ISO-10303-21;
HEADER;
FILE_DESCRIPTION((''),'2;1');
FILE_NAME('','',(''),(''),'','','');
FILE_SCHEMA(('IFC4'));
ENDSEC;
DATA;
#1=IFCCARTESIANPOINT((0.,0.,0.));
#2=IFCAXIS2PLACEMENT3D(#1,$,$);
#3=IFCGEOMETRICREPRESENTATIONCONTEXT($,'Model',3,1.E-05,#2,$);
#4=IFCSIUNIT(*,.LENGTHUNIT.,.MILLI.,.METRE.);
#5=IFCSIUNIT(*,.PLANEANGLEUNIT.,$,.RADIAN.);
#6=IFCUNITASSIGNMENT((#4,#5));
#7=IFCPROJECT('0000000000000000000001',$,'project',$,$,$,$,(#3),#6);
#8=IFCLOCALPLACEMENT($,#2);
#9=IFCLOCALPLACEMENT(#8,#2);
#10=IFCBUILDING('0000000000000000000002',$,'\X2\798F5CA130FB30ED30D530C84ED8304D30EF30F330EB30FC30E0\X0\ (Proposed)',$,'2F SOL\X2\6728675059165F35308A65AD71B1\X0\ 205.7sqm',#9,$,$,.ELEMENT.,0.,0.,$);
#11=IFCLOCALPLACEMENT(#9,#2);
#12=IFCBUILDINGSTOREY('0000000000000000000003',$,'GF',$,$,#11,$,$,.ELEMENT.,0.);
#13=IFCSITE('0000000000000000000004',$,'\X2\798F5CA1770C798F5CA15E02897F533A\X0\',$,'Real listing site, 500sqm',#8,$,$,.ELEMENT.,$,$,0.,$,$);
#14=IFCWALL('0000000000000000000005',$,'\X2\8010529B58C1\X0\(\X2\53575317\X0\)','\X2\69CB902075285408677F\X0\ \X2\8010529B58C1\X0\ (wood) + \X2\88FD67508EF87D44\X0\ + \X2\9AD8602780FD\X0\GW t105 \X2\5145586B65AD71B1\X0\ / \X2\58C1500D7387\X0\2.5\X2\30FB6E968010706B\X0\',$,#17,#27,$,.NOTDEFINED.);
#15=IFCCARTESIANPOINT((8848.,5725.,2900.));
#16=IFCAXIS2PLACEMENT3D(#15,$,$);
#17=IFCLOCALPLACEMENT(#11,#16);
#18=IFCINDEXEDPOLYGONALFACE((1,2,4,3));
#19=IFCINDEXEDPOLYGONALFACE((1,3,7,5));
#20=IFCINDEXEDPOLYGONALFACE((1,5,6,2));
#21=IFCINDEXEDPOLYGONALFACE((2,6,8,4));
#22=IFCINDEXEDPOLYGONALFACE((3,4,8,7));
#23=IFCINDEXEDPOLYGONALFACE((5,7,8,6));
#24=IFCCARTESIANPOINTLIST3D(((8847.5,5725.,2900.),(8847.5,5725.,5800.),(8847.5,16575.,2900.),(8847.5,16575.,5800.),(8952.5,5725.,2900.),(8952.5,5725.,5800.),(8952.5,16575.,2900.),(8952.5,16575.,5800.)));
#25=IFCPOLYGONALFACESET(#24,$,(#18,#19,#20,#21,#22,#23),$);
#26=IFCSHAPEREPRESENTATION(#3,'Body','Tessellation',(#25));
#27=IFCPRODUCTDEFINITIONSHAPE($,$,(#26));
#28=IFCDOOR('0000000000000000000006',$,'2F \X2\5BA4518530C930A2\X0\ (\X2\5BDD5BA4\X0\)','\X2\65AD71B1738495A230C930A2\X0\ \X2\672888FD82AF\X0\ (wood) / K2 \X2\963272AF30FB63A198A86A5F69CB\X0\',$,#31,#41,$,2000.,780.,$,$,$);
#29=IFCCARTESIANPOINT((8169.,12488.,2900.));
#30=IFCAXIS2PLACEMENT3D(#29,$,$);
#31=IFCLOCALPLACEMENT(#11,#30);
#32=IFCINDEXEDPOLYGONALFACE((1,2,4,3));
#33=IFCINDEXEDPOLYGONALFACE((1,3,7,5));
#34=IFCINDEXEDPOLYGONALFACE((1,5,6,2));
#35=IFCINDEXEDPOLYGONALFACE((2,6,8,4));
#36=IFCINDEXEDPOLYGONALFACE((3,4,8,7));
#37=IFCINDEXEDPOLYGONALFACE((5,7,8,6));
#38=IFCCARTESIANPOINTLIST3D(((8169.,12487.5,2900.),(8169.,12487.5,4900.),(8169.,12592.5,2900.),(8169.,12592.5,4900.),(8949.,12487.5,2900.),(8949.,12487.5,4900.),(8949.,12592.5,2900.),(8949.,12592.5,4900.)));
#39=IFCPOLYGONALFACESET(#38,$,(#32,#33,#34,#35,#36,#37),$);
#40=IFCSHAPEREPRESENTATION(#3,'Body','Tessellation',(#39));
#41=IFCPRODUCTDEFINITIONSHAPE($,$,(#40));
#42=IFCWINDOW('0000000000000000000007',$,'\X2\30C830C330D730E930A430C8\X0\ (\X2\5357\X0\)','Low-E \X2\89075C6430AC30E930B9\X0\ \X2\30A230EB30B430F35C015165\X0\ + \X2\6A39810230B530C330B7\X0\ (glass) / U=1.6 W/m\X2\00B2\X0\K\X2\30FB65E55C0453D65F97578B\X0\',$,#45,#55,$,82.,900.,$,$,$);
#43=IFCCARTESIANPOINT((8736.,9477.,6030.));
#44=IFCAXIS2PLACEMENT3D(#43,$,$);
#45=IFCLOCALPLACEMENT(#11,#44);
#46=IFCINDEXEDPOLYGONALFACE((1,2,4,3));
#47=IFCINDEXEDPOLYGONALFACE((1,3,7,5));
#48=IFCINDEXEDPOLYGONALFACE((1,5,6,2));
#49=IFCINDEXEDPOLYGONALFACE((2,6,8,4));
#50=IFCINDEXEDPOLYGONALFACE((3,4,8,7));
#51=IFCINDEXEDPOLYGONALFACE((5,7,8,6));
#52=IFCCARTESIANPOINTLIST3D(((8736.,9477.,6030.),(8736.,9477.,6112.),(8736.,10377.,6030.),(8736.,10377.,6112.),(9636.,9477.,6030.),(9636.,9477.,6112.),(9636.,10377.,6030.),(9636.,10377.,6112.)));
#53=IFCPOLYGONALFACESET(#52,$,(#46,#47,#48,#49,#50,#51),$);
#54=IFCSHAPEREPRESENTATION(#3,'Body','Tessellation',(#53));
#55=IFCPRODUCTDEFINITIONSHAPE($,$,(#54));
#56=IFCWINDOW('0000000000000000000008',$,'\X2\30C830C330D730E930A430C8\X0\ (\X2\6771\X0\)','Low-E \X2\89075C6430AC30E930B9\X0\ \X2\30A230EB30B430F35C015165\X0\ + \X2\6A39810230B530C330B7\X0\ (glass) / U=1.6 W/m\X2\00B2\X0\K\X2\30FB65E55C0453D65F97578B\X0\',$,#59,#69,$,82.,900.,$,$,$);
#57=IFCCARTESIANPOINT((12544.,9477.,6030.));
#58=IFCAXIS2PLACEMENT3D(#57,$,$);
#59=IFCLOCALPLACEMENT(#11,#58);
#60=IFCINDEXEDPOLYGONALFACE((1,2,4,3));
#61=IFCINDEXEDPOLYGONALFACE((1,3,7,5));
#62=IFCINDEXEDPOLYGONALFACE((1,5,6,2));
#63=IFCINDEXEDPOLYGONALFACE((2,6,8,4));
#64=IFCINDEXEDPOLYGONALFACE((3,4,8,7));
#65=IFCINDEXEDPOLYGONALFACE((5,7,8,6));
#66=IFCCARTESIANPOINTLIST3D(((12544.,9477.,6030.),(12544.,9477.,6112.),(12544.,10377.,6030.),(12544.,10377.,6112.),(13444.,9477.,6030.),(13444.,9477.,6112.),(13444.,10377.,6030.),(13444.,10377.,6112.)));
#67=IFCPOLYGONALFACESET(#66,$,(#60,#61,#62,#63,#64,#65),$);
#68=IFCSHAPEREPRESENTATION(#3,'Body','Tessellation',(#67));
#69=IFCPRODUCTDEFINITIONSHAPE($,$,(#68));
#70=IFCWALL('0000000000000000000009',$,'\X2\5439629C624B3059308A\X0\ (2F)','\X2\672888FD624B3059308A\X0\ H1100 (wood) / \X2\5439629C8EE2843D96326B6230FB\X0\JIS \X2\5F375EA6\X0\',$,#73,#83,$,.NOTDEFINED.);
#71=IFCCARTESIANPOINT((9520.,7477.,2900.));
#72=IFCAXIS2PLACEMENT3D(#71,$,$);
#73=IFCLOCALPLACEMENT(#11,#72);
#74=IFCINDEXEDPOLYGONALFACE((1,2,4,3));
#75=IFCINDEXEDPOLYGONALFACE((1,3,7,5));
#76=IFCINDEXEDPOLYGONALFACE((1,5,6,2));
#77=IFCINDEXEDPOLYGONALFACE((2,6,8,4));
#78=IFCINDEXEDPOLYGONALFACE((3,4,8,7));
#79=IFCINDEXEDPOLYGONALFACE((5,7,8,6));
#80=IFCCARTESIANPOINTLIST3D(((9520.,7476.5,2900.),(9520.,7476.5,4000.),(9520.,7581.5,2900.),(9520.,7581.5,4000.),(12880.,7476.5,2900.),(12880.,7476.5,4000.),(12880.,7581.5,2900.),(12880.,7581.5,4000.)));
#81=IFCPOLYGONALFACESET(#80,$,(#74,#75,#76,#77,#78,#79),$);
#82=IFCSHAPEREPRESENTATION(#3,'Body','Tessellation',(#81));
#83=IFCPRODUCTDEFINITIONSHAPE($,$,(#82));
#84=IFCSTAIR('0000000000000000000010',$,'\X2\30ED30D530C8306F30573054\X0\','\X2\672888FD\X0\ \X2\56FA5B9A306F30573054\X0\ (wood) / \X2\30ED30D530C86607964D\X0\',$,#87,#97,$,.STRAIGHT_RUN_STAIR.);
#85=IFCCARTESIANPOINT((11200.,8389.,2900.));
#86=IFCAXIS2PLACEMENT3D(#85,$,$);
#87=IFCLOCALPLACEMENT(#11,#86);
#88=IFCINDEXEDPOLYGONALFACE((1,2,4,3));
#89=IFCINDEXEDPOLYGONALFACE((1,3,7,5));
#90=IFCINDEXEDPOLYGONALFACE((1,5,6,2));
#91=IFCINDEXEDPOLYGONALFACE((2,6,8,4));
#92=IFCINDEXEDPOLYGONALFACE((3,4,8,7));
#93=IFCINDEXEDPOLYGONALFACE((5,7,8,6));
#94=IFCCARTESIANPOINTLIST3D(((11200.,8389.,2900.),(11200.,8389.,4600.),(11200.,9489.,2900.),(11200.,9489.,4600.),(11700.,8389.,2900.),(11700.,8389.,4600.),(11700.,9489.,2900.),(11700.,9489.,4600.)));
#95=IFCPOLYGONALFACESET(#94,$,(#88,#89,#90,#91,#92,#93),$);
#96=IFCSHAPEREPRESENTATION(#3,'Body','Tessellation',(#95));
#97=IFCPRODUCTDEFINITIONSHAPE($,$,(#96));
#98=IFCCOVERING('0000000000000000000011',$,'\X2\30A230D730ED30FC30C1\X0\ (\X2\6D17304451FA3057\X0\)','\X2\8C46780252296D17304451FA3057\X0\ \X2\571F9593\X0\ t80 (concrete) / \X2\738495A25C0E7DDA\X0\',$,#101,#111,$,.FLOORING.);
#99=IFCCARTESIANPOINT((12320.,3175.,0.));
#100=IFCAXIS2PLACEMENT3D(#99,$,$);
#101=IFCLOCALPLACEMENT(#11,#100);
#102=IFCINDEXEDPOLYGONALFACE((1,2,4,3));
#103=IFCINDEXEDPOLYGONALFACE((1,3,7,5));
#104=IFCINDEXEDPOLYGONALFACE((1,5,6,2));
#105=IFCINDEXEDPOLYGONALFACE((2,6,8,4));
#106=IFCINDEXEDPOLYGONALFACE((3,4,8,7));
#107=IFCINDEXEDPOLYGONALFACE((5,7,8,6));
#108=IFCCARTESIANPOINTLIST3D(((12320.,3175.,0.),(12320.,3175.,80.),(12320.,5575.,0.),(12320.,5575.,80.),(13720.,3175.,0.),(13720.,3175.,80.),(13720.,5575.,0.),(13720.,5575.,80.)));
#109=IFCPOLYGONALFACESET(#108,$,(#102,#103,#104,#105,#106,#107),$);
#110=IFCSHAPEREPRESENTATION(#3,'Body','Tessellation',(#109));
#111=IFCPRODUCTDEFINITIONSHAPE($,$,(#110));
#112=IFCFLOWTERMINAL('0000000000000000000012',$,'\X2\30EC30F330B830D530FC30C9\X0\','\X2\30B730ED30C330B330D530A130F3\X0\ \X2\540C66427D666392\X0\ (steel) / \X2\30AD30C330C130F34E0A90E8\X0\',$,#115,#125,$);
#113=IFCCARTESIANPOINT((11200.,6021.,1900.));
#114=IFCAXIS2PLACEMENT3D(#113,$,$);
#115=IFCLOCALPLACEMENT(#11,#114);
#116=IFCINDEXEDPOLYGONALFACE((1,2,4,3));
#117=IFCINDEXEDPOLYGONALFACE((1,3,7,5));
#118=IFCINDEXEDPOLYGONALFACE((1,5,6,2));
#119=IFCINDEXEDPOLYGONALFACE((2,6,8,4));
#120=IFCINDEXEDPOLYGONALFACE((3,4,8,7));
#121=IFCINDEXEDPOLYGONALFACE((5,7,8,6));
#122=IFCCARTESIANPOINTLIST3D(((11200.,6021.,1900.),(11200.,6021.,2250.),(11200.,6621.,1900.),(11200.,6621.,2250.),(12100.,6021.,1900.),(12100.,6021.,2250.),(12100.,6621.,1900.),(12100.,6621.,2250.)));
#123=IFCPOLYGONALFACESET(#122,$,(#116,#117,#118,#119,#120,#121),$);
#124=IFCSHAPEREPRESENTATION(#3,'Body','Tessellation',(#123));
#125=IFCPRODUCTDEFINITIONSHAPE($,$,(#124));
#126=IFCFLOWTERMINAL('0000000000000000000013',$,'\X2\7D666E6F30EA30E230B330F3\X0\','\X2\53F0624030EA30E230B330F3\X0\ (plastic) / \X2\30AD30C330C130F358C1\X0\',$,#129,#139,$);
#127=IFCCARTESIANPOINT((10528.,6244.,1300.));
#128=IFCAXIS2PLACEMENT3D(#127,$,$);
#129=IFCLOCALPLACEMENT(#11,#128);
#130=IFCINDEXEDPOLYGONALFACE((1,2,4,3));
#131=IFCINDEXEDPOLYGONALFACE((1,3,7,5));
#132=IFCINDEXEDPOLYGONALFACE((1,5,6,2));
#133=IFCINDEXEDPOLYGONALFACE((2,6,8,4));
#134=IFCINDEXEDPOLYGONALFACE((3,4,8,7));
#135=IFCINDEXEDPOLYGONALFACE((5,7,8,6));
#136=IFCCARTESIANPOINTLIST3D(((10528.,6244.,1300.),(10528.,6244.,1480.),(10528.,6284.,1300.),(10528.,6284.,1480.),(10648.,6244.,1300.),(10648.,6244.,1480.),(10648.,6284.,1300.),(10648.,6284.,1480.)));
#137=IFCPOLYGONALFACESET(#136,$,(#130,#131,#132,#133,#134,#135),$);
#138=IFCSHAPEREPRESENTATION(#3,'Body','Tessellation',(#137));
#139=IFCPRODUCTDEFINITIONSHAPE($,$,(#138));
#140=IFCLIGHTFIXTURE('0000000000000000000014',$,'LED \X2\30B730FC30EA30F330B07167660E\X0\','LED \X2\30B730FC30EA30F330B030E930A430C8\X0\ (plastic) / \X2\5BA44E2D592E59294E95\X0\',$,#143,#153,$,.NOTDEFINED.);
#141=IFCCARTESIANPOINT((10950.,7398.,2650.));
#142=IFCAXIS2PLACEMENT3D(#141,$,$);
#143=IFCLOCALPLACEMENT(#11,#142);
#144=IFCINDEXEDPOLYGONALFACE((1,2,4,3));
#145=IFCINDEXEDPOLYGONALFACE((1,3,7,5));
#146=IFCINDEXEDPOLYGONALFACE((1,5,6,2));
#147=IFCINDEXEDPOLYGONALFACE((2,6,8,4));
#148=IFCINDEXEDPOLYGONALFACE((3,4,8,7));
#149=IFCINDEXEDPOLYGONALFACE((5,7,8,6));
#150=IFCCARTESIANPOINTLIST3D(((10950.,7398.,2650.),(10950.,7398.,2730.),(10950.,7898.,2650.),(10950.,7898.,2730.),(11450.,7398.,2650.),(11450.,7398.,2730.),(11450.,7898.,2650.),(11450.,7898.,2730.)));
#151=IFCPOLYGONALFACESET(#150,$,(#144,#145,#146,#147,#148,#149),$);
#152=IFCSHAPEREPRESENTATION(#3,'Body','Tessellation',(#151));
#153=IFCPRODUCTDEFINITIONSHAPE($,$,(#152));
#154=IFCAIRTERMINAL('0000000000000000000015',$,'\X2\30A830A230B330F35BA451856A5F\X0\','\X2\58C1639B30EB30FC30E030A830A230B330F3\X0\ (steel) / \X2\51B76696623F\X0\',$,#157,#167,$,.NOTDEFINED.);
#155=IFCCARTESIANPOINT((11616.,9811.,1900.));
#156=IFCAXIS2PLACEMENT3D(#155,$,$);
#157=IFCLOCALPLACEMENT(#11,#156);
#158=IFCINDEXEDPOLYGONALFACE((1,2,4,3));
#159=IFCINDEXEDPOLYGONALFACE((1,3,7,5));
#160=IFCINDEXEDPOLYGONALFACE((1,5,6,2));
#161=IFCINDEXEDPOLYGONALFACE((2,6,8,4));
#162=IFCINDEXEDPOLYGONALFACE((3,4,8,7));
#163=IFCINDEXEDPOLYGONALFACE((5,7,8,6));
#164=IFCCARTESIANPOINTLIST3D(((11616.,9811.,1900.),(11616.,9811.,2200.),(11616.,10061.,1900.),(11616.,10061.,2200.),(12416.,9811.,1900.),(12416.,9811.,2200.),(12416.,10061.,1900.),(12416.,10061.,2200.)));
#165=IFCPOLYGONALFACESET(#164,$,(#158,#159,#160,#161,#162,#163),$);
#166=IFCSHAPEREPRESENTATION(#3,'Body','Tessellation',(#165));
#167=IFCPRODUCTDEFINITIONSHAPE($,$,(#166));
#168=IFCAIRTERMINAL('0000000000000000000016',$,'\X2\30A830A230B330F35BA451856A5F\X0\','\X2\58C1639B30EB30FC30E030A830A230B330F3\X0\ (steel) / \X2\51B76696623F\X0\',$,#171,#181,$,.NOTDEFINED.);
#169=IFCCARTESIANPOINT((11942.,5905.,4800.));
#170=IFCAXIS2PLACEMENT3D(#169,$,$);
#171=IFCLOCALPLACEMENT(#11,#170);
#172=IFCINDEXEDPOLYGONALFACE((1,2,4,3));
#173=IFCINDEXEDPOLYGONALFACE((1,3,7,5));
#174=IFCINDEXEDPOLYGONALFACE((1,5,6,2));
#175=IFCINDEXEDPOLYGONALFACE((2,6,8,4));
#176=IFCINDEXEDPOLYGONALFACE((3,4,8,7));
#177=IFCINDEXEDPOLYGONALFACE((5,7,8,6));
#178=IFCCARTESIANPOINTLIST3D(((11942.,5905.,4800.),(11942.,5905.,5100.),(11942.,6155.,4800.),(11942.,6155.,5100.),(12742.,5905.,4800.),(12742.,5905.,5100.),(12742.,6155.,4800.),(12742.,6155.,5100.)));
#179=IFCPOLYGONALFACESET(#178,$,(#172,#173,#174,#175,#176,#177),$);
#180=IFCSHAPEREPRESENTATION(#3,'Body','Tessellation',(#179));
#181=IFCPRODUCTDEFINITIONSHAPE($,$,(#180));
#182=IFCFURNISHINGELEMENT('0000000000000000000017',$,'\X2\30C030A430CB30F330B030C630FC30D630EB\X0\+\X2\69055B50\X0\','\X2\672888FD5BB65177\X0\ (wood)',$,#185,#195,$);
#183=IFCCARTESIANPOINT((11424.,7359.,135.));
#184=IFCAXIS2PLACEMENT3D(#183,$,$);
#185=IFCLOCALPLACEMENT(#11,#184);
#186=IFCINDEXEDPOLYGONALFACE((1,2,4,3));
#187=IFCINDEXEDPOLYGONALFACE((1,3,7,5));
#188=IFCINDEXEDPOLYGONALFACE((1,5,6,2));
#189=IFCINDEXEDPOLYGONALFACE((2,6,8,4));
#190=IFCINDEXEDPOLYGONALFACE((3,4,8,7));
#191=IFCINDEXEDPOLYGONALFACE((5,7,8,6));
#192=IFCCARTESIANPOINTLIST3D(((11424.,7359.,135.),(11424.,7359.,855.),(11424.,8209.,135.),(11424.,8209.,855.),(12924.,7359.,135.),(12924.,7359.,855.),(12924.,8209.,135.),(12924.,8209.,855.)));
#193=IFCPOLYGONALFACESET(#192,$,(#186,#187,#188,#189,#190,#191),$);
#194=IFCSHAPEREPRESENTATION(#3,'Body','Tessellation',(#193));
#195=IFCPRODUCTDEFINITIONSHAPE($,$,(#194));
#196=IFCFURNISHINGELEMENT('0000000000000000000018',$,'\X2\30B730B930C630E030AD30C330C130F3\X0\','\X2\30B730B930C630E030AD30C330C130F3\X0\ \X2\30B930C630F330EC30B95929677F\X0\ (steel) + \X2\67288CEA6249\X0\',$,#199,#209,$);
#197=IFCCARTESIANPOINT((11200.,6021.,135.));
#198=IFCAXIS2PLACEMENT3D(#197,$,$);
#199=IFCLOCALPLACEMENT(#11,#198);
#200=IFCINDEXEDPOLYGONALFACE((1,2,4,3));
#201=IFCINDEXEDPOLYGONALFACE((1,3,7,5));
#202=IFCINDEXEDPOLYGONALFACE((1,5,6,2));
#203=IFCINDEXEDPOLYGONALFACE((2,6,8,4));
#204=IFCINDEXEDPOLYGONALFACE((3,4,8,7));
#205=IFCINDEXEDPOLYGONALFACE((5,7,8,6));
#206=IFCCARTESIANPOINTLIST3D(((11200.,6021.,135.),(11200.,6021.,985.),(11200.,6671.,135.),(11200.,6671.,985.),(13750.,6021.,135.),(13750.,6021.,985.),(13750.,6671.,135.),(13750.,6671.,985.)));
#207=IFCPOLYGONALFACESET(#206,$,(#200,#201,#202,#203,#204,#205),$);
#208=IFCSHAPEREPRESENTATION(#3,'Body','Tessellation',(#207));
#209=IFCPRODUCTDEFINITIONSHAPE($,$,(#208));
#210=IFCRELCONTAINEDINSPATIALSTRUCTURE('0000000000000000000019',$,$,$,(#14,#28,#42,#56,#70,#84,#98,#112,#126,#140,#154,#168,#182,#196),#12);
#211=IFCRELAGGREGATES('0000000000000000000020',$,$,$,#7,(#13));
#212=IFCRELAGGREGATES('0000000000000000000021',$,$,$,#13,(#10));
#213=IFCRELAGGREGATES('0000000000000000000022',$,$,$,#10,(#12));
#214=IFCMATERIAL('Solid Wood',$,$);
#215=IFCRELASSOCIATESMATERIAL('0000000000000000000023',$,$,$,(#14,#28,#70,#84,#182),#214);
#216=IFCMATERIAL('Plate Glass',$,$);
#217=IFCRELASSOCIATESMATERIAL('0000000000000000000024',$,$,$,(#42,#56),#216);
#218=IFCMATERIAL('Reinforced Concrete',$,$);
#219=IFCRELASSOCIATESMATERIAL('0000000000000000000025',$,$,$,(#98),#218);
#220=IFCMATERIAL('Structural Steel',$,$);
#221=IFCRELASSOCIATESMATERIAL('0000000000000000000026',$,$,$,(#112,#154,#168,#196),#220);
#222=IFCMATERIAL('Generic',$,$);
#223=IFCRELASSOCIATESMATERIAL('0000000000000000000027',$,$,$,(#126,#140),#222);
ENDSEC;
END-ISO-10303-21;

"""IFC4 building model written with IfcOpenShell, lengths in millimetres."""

from ifc_helpers import new_model, si_unit, frame, frame_2d, origin, place, context, project, spatial, rectangle, extrude, material, element, fill, save


model = new_model("IFC4")

# Units and contexts
model_context = context("Model", 3, precision=1e-05, world=origin())
ifc_project = project(units=[si_unit("LENGTHUNIT", "METRE", prefix="MILLI"), si_unit("PLANEANGLEUNIT", "RADIAN")], contexts=[model_context])

# Site, building, storey
site_placement = place(None, origin())
site = spatial("IfcSite", under=ifc_project, at=site_placement, Name="福岡県福岡市西区", ObjectType="Real listing site, 500sqm", CompositionType="ELEMENT", RefElevation=0.0)
building_placement = place(site_placement, origin())
building = spatial("IfcBuilding", under=site, at=building_placement, Name="福岡・ロフト付きワンルーム (Proposed)", ObjectType="2F SOL木材外張り断熱 205.7sqm", CompositionType="ELEMENT", ElevationOfRefHeight=0.0, ElevationOfTerrain=0.0)
storey_placement = place(building_placement, origin())
storey = spatial("IfcBuildingStorey", under=building, at=storey_placement, Name="GF", CompositionType="ELEMENT", Elevation=0.0)

# Shared definitions
ifc_material_1 = material(Name="Solid Wood")

# Wall, opening, door
wall_1_placement = place(storey_placement, frame((8848.0, 5725.0, 2900.0)))
wall_1 = element("IfcWall", 1, at=wall_1_placement, inside=storey, material=ifc_material_1, Name="耐力壁(南北)", Description="構造用合板 耐力壁 (wood) + 製材軸組 + 高性能GW t105 充填断熱 / 壁倍率2.5・準耐火", PredefinedType="NOTDEFINED", context=model_context, shape_type="SweptSolid", body=[
    extrude(rectangle(XDim=105.0, YDim=10850.0, at=frame_2d((52.0, 5425.0))), frame((8848.0, 5725.0, 2900.0)), (0.0, 0.0, 1.0), 2900.0),
])
opening_1_placement = place(storey_placement, frame((8169.0, 12488.0, 2900.0)))
opening_1 = element("IfcOpeningElement", 2, at=opening_1_placement, cuts=wall_1, PredefinedType="NOTDEFINED", context=model_context, shape_type="SweptSolid", body=[
    extrude(rectangle(XDim=780.0, YDim=105.0, at=frame_2d((390.0, 52.0))), frame((8169.0, 12488.0, 2900.0)), (0.0, 0.0, 1.0), 2000.0),
])
door_1_placement = place(storey_placement, frame((8169.0, 12488.0, 2900.0)))
door_1 = element("IfcDoor", 3, at=door_1_placement, inside=storey, material=ifc_material_1, Name="2F 室内ドア (寝室)", Description="断熱玄関ドア 木製芯 (wood) / K2 防犯・採風機構", OverallHeight=2000.0, OverallWidth=780.0, context=model_context, shape_type="SweptSolid", body=[
    extrude(rectangle(XDim=780.0, YDim=105.0, at=frame_2d((390.0, 52.0))), frame((8169.0, 12488.0, 2900.0)), (0.0, 0.0, 1.0), 2000.0),
])
fill(opening_1, door_1)

# Windows
ifc_material_2 = material(Name="Plate Glass")
window_1_placement = place(storey_placement, frame((8736.0, 9477.0, 6030.0)))
element("IfcWindow", 4, at=window_1_placement, inside=storey, material=ifc_material_2, Name="トップライト (南)", Description="Low-E 複層ガラス アルゴン封入 + 樹脂サッシ (glass) / U=1.6 W/m²K・日射取得型", OverallHeight=82.0, OverallWidth=900.0, context=model_context, shape_type="SweptSolid", body=[
    extrude(rectangle(XDim=900.0, YDim=900.0, at=frame_2d((450.0, 450.0))), frame((8736.0, 9477.0, 6030.0)), (0.0, 0.0, 1.0), 82.0),
])
window_2_placement = place(storey_placement, frame((12544.0, 9477.0, 6030.0)))
element("IfcWindow", 5, at=window_2_placement, inside=storey, material=ifc_material_2, Name="トップライト (東)", Description="Low-E 複層ガラス アルゴン封入 + 樹脂サッシ (glass) / U=1.6 W/m²K・日射取得型", OverallHeight=82.0, OverallWidth=900.0, context=model_context, shape_type="SweptSolid", body=[
    extrude(rectangle(XDim=900.0, YDim=900.0, at=frame_2d((450.0, 450.0))), frame((12544.0, 9477.0, 6030.0)), (0.0, 0.0, 1.0), 82.0),
])

# Wall
wall_2_placement = place(storey_placement, frame((9520.0, 7477.0, 2900.0)))
element("IfcWall", 6, at=wall_2_placement, inside=storey, material=ifc_material_1, Name="吹抜手すり (2F)", Description="木製手すり H1100 (wood) / 吹抜転落防止・JIS 強度", PredefinedType="NOTDEFINED", context=model_context, shape_type="SweptSolid", body=[
    extrude(rectangle(XDim=3360.0, YDim=105.0, at=frame_2d((1680.0, 52.0))), frame((9520.0, 7477.0, 2900.0)), (0.0, 0.0, 1.0), 1100.0),
])

# Stair
stair_placement = place(storey_placement, frame((11200.0, 8389.0, 2900.0)))
element("IfcStair", 7, at=stair_placement, inside=storey, material=ifc_material_1, Name="ロフトはしご", Description="木製 固定はしご (wood) / ロフト昇降", PredefinedType="STRAIGHT_RUN_STAIR", context=model_context, shape_type="SweptSolid", body=[
    extrude(rectangle(XDim=500.0, YDim=1100.0, at=frame_2d((250.0, 550.0))), frame((11200.0, 8389.0, 2900.0)), (0.0, 0.0, 1.0), 1700.0),
])

# Covering
ifc_material_3 = material(Name="Reinforced Concrete")
covering_placement = place(storey_placement, frame((12320.0, 3175.0, 0.0)))
element("IfcCovering", 8, at=covering_placement, inside=storey, material=ifc_material_3, Name="アプローチ (洗い出し)", Description="豆砂利洗い出し 土間 t80 (concrete) / 玄関導線", PredefinedType="FLOORING", context=model_context, shape_type="SweptSolid", body=[
    extrude(rectangle(XDim=1400.0, YDim=2400.0, at=frame_2d((700.0, 1200.0))), frame((12320.0, 3175.0, 0.0)), (0.0, 0.0, 1.0), 80.0),
])

# Flow terminals
ifc_material_4 = material(Name="Structural Steel")
flow_terminal_1_placement = place(storey_placement, frame((11200.0, 6021.0, 1900.0)))
element("IfcFlowTerminal", 9, at=flow_terminal_1_placement, inside=storey, material=ifc_material_4, Name="レンジフード", Description="シロッコファン 同時給排 (steel) / キッチン上部", context=model_context, shape_type="SweptSolid", body=[
    extrude(rectangle(XDim=900.0, YDim=600.0, at=frame_2d((450.0, 300.0))), frame((11200.0, 6021.0, 1900.0)), (0.0, 0.0, 1.0), 350.0),
])
ifc_material_5 = material(Name="Generic")
flow_terminal_2_placement = place(storey_placement, frame((10528.0, 6244.0, 1300.0)))
element("IfcFlowTerminal", 10, at=flow_terminal_2_placement, inside=storey, material=ifc_material_5, Name="給湯リモコン", Description="台所リモコン (plastic) / キッチン壁", context=model_context, shape_type="SweptSolid", body=[
    extrude(rectangle(XDim=120.0, YDim=40.0, at=frame_2d((60.0, 20.0))), frame((10528.0, 6244.0, 1300.0)), (0.0, 0.0, 1.0), 180.0),
])

# Light fixture
light_fixture_placement = place(storey_placement, frame((10950.0, 7398.0, 2650.0)))
element("IfcLightFixture", 11, at=light_fixture_placement, inside=storey, material=ifc_material_5, Name="LED シーリング照明", Description="LED シーリングライト (plastic) / 室中央天井", PredefinedType="NOTDEFINED", context=model_context, shape_type="SweptSolid", body=[
    extrude(rectangle(XDim=500.0, YDim=500.0, at=frame_2d((250.0, 250.0))), frame((10950.0, 7398.0, 2650.0)), (0.0, 0.0, 1.0), 80.0),
])

# Air terminals
air_terminal_1_placement = place(storey_placement, frame((11616.0, 9811.0, 1900.0)))
element("IfcAirTerminal", 12, at=air_terminal_1_placement, inside=storey, material=ifc_material_4, Name="エアコン室内機", Description="壁掛ルームエアコン (steel) / 冷暖房", PredefinedType="NOTDEFINED", context=model_context, shape_type="SweptSolid", body=[
    extrude(rectangle(XDim=800.0, YDim=250.0, at=frame_2d((400.0, 125.0))), frame((11616.0, 9811.0, 1900.0)), (0.0, 0.0, 1.0), 300.0),
])
air_terminal_2_placement = place(storey_placement, frame((11942.0, 5905.0, 4800.0)))
element("IfcAirTerminal", 13, at=air_terminal_2_placement, inside=storey, material=ifc_material_4, Name="エアコン室内機", Description="壁掛ルームエアコン (steel) / 冷暖房", PredefinedType="NOTDEFINED", context=model_context, shape_type="SweptSolid", body=[
    extrude(rectangle(XDim=800.0, YDim=250.0, at=frame_2d((400.0, 125.0))), frame((11942.0, 5905.0, 4800.0)), (0.0, 0.0, 1.0), 300.0),
])

# Furnishing elements
furnishing_1_placement = place(storey_placement, frame((11424.0, 7359.0, 135.0)))
element("IfcFurnishingElement", 14, at=furnishing_1_placement, inside=storey, material=ifc_material_1, Name="ダイニングテーブル+椅子", Description="木製家具 (wood)", context=model_context, shape_type="SweptSolid", body=[
    extrude(rectangle(XDim=1500.0, YDim=850.0, at=frame_2d((750.0, 425.0))), frame((11424.0, 7359.0, 135.0)), (0.0, 0.0, 1.0), 720.0),
])
furnishing_2_placement = place(storey_placement, frame((11200.0, 6021.0, 135.0)))
element("IfcFurnishingElement", 15, at=furnishing_2_placement, inside=storey, material=ifc_material_4, Name="システムキッチン", Description="システムキッチン ステンレス天板 (steel) + 木質扉", context=model_context, shape_type="SweptSolid", body=[
    extrude(rectangle(XDim=2550.0, YDim=650.0, at=frame_2d((1275.0, 325.0))), frame((11200.0, 6021.0, 135.0)), (0.0, 0.0, 1.0), 850.0),
])

save(model, "model.ifc")
